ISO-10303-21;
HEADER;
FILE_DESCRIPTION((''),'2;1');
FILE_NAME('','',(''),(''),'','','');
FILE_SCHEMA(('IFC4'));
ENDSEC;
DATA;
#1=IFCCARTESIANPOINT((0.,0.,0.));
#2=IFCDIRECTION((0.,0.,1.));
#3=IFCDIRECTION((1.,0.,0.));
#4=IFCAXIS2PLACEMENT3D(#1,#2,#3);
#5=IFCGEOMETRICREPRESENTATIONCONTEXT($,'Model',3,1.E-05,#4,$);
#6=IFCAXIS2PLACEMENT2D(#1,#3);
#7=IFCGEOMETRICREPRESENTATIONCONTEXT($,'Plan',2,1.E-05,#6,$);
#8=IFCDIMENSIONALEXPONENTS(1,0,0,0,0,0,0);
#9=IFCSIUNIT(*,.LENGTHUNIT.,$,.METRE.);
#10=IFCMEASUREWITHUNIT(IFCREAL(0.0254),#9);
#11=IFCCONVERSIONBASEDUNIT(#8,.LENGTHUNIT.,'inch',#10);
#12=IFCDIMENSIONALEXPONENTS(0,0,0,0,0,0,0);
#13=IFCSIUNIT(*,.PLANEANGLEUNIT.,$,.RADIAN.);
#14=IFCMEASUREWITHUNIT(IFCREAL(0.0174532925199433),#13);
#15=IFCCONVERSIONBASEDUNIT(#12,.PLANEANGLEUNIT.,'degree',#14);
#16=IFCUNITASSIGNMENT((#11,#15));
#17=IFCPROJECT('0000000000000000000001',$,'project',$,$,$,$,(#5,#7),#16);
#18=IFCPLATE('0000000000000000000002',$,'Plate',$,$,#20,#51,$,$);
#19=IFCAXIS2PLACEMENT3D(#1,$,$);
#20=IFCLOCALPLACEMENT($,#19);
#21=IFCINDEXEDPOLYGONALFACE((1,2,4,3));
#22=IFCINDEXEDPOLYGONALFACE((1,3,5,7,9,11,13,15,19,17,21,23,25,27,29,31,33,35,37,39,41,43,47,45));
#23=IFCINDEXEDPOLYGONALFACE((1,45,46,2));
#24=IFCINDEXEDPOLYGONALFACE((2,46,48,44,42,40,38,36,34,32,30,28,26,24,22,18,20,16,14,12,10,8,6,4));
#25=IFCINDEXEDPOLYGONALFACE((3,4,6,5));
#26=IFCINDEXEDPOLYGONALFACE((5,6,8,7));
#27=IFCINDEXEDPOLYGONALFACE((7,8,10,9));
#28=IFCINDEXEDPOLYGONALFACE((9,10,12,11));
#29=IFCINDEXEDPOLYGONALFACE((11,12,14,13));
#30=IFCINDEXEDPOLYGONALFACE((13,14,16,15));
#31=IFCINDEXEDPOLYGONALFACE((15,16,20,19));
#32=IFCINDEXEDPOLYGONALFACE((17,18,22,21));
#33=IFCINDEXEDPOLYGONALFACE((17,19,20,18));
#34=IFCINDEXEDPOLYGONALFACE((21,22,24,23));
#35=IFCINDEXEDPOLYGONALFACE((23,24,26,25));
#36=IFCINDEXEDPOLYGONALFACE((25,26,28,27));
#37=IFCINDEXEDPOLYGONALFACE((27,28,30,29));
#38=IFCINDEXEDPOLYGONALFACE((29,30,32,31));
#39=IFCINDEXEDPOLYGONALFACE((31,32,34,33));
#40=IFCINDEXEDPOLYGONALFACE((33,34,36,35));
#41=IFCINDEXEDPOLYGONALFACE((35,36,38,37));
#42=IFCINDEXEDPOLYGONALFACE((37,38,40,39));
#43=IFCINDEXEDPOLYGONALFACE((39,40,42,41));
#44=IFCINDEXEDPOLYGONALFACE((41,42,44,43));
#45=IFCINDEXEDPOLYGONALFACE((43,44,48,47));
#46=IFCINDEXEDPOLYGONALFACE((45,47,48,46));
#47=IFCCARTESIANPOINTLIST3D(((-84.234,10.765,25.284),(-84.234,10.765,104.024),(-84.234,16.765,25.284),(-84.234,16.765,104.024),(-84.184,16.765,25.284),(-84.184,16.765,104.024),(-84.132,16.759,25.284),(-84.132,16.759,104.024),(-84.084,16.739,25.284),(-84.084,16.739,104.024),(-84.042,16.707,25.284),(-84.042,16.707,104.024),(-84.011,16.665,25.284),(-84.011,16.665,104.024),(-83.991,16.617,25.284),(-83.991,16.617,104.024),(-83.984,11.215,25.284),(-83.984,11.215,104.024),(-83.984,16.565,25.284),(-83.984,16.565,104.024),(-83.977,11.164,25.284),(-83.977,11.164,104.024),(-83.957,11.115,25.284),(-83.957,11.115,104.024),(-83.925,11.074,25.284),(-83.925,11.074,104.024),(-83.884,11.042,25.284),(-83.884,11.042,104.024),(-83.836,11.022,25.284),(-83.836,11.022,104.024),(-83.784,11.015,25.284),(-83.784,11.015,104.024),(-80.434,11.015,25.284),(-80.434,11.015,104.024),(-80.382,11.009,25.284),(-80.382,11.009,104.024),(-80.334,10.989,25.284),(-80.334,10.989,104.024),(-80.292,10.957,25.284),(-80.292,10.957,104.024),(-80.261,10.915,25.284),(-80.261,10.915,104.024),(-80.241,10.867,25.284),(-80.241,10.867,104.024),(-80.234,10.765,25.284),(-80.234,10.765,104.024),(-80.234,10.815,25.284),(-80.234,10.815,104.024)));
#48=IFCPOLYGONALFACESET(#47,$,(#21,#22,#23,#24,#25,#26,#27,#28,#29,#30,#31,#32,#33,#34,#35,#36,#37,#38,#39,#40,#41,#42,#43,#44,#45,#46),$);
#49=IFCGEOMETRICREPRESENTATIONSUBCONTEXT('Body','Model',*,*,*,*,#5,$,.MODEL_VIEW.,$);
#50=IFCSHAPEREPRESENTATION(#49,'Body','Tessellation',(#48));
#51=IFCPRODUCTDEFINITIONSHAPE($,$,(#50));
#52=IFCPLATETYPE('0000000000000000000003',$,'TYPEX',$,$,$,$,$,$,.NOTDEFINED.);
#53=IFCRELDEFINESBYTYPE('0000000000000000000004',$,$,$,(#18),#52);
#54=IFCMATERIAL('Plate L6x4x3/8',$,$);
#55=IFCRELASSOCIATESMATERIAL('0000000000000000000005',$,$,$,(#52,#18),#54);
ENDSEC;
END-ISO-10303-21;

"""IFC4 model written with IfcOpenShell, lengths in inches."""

from ifc_helpers import new_model, entity, si_unit, converted_unit, frame, frame_2d, origin_with_axes, place, context, subcontext, project, l_section, extrude, material, material_profile, profile_set, profile_usage, type_object, element, save


model = new_model("IFC4")

# Units and contexts
model_context = context("Model", 3, precision=1e-05, world=origin_with_axes())
plan_context = context("Plan", 2, precision=1e-05, world=frame_2d((0.0, 0.0, 0.0), x_axis=(1.0, 0.0, 0.0)))
body_context = subcontext(model_context, "Body", "Model", "MODEL_VIEW")
ifc_project = project(units=[converted_unit("LENGTHUNIT", "inch", entity("IfcReal", 0.0254), si_unit("LENGTHUNIT", "METRE"), dimensions=[1, 0, 0, 0, 0, 0, 0]), converted_unit("PLANEANGLEUNIT", "degree", entity("IfcReal", 0.0174532925199433), si_unit("PLANEANGLEUNIT", "RADIAN"), dimensions=[0, 0, 0, 0, 0, 0, 0])], contexts=[model_context, plan_context])

# Plate
ifc_material = material(Name="Plate L6x4x3/8")
ifc_material_profile = material_profile(ifc_material, l_section(Depth=6.0, Width=4.0, Thickness=0.25, FilletRadius=0.2, EdgeRadius=0.2), Name="Plate L6x4x3/8")
ifc_profile_set = profile_set([ifc_material_profile], Name="Plate L6x4x3/8")
ifc_profile_usage = profile_usage(ifc_profile_set)
plate_type = type_object("IfcPlateType", Name="TYPEX", PredefinedType="NOTDEFINED", material=ifc_profile_set)
plate_placement = place(None, frame((-82.234, 13.765, 25.284), z_axis=(0.0, 0.0, 1.0), x_axis=(1.0, 0.0, 0.0)))
element("IfcPlate", 1, at=plate_placement, type_object=plate_type, material=ifc_profile_usage, Name="Plate", context=body_context, shape_type="SweptSolid", body=[
    extrude(l_section(Depth=6.0, Width=4.0, Thickness=0.25, FilletRadius=0.2, EdgeRadius=0.2), None, (0.0, 0.0, 1.0), 78.74),
])

save(model, "model.ifc")
